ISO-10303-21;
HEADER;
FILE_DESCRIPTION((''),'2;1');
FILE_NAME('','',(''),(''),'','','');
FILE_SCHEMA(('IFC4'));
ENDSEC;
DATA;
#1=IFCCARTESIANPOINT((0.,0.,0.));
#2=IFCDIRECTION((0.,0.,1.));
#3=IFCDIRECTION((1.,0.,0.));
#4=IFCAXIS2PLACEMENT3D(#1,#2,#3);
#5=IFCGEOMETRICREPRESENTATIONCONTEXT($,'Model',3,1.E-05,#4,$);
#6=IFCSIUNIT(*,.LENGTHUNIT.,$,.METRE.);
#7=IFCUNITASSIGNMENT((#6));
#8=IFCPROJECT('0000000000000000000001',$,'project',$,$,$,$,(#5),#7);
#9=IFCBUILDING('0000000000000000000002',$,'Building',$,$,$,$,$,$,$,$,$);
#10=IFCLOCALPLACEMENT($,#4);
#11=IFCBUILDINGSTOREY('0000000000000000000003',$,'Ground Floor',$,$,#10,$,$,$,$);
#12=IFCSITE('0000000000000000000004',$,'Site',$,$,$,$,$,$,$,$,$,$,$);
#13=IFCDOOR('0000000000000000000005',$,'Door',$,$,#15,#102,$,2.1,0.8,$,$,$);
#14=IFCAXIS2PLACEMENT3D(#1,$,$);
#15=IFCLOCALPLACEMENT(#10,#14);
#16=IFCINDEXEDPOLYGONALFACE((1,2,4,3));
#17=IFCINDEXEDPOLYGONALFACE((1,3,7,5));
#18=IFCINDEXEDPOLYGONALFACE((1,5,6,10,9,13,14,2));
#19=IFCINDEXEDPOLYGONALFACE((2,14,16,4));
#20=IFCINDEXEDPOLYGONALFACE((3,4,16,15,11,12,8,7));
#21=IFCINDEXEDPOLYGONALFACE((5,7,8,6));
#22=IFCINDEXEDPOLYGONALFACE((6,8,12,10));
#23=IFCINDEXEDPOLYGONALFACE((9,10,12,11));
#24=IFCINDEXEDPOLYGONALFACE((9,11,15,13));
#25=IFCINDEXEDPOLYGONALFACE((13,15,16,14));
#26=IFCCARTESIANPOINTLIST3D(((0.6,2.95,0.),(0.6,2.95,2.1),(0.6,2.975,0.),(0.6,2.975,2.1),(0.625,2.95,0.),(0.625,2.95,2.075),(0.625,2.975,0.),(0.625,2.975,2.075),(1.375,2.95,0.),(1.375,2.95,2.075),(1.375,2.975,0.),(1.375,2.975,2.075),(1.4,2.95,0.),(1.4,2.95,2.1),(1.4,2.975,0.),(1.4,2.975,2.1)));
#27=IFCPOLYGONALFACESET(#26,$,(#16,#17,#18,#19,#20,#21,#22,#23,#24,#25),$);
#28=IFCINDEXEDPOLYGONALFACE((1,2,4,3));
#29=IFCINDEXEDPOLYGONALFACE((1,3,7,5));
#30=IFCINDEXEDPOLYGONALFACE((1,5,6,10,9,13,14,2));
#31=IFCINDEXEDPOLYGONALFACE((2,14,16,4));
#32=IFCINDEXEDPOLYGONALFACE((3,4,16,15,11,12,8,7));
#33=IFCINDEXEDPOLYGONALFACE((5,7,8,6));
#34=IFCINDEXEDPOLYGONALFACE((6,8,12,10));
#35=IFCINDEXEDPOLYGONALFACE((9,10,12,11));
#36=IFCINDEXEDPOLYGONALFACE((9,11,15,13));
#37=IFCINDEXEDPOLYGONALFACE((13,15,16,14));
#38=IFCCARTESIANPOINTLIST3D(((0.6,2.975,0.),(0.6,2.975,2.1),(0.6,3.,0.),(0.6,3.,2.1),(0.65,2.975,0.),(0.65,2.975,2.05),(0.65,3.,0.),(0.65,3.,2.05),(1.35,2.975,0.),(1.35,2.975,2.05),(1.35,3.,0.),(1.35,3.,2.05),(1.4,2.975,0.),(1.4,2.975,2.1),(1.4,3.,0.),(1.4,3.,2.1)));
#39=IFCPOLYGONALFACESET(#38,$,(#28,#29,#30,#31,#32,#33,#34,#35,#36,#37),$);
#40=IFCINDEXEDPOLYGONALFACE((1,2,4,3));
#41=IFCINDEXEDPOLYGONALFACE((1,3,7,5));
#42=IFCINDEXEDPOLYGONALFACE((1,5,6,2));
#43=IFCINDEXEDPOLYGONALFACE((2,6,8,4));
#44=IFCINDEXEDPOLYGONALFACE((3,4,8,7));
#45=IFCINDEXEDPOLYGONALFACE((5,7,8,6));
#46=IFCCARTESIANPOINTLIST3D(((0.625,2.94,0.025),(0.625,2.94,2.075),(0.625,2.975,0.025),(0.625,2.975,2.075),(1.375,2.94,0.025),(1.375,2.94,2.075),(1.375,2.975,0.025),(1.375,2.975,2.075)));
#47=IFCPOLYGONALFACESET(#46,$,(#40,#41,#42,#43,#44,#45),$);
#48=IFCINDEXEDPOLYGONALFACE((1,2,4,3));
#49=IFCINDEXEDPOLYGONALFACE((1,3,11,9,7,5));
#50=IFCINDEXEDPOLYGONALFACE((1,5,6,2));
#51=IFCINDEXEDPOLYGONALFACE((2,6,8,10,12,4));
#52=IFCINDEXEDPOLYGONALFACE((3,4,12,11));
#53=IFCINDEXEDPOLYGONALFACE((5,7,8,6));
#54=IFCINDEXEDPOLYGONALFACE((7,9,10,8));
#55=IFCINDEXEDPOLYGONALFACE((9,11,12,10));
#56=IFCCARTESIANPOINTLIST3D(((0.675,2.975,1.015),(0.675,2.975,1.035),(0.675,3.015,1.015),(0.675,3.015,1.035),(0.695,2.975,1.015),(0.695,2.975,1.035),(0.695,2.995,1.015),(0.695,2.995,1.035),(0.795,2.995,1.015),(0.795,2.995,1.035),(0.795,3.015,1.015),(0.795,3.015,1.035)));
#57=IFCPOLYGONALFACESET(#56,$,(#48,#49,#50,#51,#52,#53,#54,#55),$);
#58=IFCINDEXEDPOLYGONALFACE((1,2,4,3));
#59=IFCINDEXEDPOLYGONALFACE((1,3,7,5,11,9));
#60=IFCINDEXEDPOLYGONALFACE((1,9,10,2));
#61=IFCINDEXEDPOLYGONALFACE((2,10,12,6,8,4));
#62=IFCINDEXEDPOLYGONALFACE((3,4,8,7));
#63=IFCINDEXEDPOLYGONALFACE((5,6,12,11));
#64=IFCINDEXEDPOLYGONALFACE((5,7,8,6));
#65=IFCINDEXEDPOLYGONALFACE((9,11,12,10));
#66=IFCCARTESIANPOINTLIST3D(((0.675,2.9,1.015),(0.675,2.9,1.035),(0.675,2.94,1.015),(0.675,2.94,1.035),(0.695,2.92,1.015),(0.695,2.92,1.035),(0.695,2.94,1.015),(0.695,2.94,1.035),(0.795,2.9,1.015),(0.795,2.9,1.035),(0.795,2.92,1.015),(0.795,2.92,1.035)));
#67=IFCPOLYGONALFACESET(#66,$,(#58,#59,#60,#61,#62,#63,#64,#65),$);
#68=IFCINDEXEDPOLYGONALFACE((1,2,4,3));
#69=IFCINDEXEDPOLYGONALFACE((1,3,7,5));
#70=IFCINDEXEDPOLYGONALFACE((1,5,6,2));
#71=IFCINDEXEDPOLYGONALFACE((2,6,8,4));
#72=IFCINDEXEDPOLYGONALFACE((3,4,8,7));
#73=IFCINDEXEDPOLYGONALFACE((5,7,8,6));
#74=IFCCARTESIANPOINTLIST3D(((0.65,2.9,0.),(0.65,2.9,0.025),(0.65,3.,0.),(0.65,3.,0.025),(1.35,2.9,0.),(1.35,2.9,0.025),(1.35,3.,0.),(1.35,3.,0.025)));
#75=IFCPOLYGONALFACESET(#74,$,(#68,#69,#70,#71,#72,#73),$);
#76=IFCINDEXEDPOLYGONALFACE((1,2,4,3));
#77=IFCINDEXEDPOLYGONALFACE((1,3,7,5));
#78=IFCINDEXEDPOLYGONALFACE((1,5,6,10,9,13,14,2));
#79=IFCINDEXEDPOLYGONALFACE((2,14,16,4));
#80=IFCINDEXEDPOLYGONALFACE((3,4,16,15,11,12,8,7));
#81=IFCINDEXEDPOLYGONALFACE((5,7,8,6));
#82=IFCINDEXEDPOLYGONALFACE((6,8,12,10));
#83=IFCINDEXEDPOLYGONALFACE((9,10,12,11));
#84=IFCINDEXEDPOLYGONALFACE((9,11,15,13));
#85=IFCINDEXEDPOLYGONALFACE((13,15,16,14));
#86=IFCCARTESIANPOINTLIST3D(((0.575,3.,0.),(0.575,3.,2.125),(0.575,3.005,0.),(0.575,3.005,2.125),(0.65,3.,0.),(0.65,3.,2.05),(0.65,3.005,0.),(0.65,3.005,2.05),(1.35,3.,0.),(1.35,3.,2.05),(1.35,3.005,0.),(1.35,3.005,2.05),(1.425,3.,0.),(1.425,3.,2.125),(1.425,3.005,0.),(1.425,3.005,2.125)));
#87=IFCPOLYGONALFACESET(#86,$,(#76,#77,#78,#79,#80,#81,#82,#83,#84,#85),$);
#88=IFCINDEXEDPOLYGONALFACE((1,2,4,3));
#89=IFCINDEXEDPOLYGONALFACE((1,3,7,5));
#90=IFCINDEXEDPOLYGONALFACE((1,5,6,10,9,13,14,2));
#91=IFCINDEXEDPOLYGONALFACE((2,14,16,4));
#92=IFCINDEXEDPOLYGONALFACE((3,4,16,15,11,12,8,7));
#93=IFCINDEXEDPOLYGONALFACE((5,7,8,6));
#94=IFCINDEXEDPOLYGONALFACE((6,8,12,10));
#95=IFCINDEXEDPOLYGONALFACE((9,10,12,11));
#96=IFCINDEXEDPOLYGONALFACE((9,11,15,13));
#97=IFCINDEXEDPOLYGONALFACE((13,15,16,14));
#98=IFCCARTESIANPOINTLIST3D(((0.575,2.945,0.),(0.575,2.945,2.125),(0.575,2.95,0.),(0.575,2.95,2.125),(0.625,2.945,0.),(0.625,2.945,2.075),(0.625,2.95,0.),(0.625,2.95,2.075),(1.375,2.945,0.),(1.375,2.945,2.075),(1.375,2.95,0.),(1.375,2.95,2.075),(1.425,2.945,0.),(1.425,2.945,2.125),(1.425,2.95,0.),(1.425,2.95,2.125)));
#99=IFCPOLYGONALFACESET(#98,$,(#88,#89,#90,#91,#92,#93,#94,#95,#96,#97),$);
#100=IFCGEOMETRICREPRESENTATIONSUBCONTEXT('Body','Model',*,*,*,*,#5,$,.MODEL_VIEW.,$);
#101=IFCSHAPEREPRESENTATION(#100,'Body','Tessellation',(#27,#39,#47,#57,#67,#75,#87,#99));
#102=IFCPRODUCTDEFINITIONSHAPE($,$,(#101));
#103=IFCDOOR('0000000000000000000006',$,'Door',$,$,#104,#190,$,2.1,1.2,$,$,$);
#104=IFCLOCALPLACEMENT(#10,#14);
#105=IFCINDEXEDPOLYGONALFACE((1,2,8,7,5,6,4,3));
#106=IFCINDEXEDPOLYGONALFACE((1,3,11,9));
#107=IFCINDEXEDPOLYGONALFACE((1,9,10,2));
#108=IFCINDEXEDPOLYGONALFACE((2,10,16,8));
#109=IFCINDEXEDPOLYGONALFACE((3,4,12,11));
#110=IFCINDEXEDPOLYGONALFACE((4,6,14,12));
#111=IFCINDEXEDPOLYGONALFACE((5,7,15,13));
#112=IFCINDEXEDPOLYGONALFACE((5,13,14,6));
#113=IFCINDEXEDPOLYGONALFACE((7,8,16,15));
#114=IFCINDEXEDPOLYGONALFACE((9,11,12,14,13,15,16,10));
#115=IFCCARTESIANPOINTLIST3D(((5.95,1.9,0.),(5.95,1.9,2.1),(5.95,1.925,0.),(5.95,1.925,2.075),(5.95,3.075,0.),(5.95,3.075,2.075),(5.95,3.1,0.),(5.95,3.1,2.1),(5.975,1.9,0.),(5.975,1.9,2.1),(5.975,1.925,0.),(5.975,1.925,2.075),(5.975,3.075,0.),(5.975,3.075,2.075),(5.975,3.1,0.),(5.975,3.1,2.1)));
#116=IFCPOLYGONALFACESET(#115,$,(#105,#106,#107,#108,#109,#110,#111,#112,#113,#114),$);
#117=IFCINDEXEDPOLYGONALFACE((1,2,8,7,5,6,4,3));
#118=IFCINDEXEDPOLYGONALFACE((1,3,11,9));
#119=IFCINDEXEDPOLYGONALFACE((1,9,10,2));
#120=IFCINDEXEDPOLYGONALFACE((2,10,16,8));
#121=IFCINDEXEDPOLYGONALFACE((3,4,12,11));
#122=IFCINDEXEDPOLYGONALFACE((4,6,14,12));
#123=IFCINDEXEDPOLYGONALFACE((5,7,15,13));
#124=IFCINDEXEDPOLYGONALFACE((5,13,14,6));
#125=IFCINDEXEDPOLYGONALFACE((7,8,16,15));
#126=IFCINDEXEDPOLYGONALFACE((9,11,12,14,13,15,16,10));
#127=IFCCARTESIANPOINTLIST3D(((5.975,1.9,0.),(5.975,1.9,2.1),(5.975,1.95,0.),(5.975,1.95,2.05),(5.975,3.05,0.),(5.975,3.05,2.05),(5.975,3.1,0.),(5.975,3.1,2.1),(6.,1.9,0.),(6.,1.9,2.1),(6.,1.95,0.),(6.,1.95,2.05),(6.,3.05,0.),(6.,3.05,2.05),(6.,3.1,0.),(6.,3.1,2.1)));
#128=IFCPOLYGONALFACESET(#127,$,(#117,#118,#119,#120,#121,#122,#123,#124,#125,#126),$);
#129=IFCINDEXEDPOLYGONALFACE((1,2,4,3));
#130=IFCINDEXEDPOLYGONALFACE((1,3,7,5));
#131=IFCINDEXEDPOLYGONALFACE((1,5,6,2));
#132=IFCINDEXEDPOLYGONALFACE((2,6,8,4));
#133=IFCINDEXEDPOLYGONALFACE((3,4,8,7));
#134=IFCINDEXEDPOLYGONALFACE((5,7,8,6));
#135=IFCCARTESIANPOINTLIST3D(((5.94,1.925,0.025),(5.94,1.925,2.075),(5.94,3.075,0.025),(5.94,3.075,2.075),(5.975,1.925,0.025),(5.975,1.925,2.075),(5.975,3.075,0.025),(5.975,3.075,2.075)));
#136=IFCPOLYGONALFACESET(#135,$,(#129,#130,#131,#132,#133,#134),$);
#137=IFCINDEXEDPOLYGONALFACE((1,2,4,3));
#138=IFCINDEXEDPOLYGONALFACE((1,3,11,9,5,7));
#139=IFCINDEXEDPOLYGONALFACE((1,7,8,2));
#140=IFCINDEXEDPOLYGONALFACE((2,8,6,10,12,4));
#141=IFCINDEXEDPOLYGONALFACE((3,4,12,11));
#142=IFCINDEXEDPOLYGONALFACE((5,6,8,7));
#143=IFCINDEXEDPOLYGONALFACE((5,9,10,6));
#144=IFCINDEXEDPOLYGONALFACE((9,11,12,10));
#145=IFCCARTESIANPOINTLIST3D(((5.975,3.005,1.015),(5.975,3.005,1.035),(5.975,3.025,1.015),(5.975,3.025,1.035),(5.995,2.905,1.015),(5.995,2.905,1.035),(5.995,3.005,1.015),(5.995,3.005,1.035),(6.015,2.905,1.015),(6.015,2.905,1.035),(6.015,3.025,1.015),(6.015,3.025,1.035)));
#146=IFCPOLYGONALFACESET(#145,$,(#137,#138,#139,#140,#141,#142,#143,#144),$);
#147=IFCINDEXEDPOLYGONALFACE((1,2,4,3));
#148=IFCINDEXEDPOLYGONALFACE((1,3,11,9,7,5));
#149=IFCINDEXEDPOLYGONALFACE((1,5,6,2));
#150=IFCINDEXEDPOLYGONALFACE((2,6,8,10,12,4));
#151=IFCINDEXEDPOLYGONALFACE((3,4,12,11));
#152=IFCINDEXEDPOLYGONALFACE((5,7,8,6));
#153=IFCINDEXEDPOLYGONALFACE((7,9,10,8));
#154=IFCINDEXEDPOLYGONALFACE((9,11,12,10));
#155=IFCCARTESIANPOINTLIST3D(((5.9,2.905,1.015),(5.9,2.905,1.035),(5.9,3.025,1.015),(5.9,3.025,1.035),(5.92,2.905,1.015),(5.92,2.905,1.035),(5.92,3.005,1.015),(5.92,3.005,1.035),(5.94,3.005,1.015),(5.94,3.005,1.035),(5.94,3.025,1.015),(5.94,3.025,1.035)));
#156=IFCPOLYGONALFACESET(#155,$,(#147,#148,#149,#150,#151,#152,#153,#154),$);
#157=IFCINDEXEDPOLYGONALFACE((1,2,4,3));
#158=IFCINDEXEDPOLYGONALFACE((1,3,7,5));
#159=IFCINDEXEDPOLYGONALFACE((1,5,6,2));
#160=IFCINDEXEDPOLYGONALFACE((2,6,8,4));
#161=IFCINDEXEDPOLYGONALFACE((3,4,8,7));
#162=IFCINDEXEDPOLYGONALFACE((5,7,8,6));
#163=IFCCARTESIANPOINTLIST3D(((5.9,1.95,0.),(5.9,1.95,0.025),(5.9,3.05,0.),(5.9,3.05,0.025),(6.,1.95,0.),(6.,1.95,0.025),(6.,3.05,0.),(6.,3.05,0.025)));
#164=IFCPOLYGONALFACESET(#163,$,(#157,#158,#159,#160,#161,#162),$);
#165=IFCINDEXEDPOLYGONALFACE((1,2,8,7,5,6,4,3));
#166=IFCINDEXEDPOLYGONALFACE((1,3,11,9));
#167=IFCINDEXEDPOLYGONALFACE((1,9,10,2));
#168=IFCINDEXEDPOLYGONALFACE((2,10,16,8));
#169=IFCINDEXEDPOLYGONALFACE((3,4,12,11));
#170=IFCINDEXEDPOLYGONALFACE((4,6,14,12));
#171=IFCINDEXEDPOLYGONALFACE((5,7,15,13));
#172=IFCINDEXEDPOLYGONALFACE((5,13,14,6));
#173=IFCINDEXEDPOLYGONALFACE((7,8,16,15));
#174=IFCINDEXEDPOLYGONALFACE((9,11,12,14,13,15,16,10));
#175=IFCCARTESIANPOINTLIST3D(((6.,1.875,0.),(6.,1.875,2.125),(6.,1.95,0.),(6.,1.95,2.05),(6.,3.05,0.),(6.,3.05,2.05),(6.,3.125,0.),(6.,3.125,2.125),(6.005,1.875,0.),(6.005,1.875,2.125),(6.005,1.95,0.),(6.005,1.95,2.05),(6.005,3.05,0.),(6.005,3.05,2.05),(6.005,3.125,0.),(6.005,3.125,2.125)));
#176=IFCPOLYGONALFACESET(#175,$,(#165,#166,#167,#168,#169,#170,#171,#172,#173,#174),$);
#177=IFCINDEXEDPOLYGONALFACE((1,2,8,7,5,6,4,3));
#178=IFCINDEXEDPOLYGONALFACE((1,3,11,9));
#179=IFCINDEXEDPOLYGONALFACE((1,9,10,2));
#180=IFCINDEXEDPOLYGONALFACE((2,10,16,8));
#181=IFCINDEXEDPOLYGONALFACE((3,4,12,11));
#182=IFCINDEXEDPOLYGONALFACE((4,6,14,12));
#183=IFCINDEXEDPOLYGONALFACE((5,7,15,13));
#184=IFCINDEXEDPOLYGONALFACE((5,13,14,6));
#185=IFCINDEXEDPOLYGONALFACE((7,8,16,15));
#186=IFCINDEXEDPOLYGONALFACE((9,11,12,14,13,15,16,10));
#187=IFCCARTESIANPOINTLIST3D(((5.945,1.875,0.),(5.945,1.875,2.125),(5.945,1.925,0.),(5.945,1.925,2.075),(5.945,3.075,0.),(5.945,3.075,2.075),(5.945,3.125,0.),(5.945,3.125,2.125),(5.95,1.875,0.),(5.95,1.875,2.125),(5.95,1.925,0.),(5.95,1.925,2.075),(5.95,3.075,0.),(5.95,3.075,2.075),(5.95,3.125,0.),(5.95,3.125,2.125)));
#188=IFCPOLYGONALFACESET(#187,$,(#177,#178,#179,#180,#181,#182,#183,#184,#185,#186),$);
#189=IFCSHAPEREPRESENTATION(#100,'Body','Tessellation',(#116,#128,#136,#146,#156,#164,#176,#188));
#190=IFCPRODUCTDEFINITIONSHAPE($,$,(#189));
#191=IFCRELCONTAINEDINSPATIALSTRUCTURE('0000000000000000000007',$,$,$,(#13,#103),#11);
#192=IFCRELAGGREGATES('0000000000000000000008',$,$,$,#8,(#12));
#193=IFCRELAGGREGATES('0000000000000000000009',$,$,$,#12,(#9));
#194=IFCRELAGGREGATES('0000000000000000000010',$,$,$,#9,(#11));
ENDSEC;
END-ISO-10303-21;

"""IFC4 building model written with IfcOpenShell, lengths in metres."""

from ifc_helpers import new_model, si_unit, frame, origin_with_axes, place, context, subcontext, project, spatial, line, indexed_curve, outline, extrude, element, save


model = new_model("IFC4")

# Units and contexts
model_context = context("Model", 3, precision=1e-05, world=origin_with_axes())
body_context = subcontext(model_context, "Body", "Model", "MODEL_VIEW")
ifc_project = project(units=[si_unit("LENGTHUNIT", "METRE")], contexts=[model_context])

# Site, building, storey
site = spatial("IfcSite", under=ifc_project, Name="Site")
building = spatial("IfcBuilding", under=site, Name="Building")
storey_placement = place(None, origin_with_axes())
storey = spatial("IfcBuildingStorey", under=building, at=storey_placement, Name="Ground Floor")

# Doors
door_1_placement = place(storey_placement, frame((1.4, 3.0, 0.0), z_axis=(0.0, 0.0, 1.0), x_axis=(-1.0, 0.0, 0.0)))
element("IfcDoor", 1, at=door_1_placement, inside=storey, Name="Door", OverallHeight=2.1, OverallWidth=0.8, context=body_context, shape_type="SweptSolid", body=[
    extrude(outline(indexed_curve([(0.0, 0.0), (0.0, 2.1), (0.8, 2.1), (0.8, 0.0), (0.775, 0.0), (0.775, 2.075), (0.025, 2.075), (0.025, 0.0)], segments=[line(1, 2, 3, 4, 5, 6, 7, 8, 1)])), frame((0.0, 0.025, 0.0), z_axis=(0.0, -1.0, 0.0), x_axis=(1.0, 0.0, 0.0)), (0.0, 0.0, -1.0), 0.025),
    extrude(outline(indexed_curve([(0.0, 0.0), (0.0, 2.1), (0.8, 2.1), (0.8, 0.0), (0.75, 0.0), (0.75, 2.05), (0.05, 2.05), (0.05, 0.0)], segments=[line(1, 2, 3, 4, 5, 6, 7, 8, 1)])), frame((0.0, 0.0, 0.0), z_axis=(0.0, -1.0, 0.0), x_axis=(1.0, 0.0, 0.0)), (0.0, 0.0, -1.0), 0.025),
    extrude(outline(indexed_curve([(0.0, 0.0), (0.75, 0.0), (0.75, 0.035), (0.0, 0.035)], segments=[line(1, 2, 3, 4, 1)])), frame((0.025, 0.025, 0.025), z_axis=(0.0, 0.0, 1.0), x_axis=(1.0, 0.0, 0.0)), (0.0, 0.0, 1.0), 2.05),
    extrude(outline(indexed_curve([(0.0, 0.0), (0.0, -0.04), (-0.12, -0.04), (-0.12, -0.02), (-0.02, -0.02), (-0.02, 0.0)], segments=[line(1, 2, 3, 4, 5, 6, 1)])), frame((0.725, 0.025, 1.015), z_axis=(0.0, 0.0, 1.0), x_axis=(1.0, 0.0, 0.0)), (0.0, 0.0, 1.0), 0.02),
    extrude(outline(indexed_curve([(0.0, 0.0), (0.0, 0.04), (-0.12, 0.04), (-0.12, 0.02), (-0.02, 0.02), (-0.02, 0.0)], segments=[line(1, 2, 3, 4, 5, 6, 1)])), frame((0.725, 0.06, 1.015), z_axis=(0.0, 0.0, 1.0), x_axis=(1.0, 0.0, 0.0)), (0.0, 0.0, 1.0), 0.02),
    extrude(outline(indexed_curve([(0.0, 0.0), (0.7, 0.0), (0.7, 0.1), (0.0, 0.1)], segments=[line(1, 2, 3, 4, 1)])), frame((0.05, 0.0, 0.0), z_axis=(0.0, 0.0, 1.0), x_axis=(1.0, 0.0, 0.0)), (0.0, 0.0, 1.0), 0.025),
    extrude(outline(indexed_curve([(0.0, 0.0), (0.0, 2.125), (0.85, 2.125), (0.85, 0.0), (0.775, 0.0), (0.775, 2.05), (0.075, 2.05), (0.075, 0.0)], segments=[line(1, 2, 3, 4, 5, 6, 7, 8, 1)])), frame((-0.025, -0.005, 0.0), z_axis=(0.0, -1.0, 0.0), x_axis=(1.0, 0.0, 0.0)), (0.0, 0.0, -1.0), 0.005),
    extrude(outline(indexed_curve([(0.0, 0.0), (0.0, 2.125), (0.85, 2.125), (0.85, 0.0), (0.8, 0.0), (0.8, 2.075), (0.05, 2.075), (0.05, 0.0)], segments=[line(1, 2, 3, 4, 5, 6, 7, 8, 1)])), frame((-0.025, 0.05, 0.0), z_axis=(0.0, -1.0, 0.0), x_axis=(1.0, 0.0, 0.0)), (0.0, 0.0, -1.0), 0.005),
])
door_2_placement = place(storey_placement, frame((6.0, 1.9, 0.0), z_axis=(0.0, 0.0, 1.0), x_axis=(0.0, 1.0, 0.0)))
element("IfcDoor", 2, at=door_2_placement, inside=storey, Name="Door", OverallHeight=2.1, OverallWidth=1.2, context=body_context, shape_type="SweptSolid", body=[
    extrude(outline(indexed_curve([(0.0, 0.0), (0.0, 2.1), (1.2, 2.1), (1.2, 0.0), (1.175, 0.0), (1.175, 2.075), (0.025, 2.075), (0.025, 0.0)], segments=[line(1, 2, 3, 4, 5, 6, 7, 8, 1)])), frame((0.0, 0.025, 0.0), z_axis=(0.0, -1.0, 0.0), x_axis=(1.0, 0.0, 0.0)), (0.0, 0.0, -1.0), 0.025),
    extrude(outline(indexed_curve([(0.0, 0.0), (0.0, 2.1), (1.2, 2.1), (1.2, 0.0), (1.15, 0.0), (1.15, 2.05), (0.05, 2.05), (0.05, 0.0)], segments=[line(1, 2, 3, 4, 5, 6, 7, 8, 1)])), frame((0.0, 0.0, 0.0), z_axis=(0.0, -1.0, 0.0), x_axis=(1.0, 0.0, 0.0)), (0.0, 0.0, -1.0), 0.025),
    extrude(outline(indexed_curve([(0.0, 0.0), (1.15, 0.0), (1.15, 0.035), (0.0, 0.035)], segments=[line(1, 2, 3, 4, 1)])), frame((0.025, 0.025, 0.025), z_axis=(0.0, 0.0, 1.0), x_axis=(1.0, 0.0, 0.0)), (0.0, 0.0, 1.0), 2.05),
    extrude(outline(indexed_curve([(0.0, 0.0), (0.0, -0.04), (-0.12, -0.04), (-0.12, -0.02), (-0.02, -0.02), (-0.02, 0.0)], segments=[line(1, 2, 3, 4, 5, 6, 1)])), frame((1.125, 0.025, 1.015), z_axis=(0.0, 0.0, 1.0), x_axis=(1.0, 0.0, 0.0)), (0.0, 0.0, 1.0), 0.02),
    extrude(outline(indexed_curve([(0.0, 0.0), (0.0, 0.04), (-0.12, 0.04), (-0.12, 0.02), (-0.02, 0.02), (-0.02, 0.0)], segments=[line(1, 2, 3, 4, 5, 6, 1)])), frame((1.125, 0.06, 1.015), z_axis=(0.0, 0.0, 1.0), x_axis=(1.0, 0.0, 0.0)), (0.0, 0.0, 1.0), 0.02),
    extrude(outline(indexed_curve([(0.0, 0.0), (1.1, 0.0), (1.1, 0.1), (0.0, 0.1)], segments=[line(1, 2, 3, 4, 1)])), frame((0.05, 0.0, 0.0), z_axis=(0.0, 0.0, 1.0), x_axis=(1.0, 0.0, 0.0)), (0.0, 0.0, 1.0), 0.025),
    extrude(outline(indexed_curve([(0.0, 0.0), (0.0, 2.125), (1.25, 2.125), (1.25, 0.0), (1.175, 0.0), (1.175, 2.05), (0.075, 2.05), (0.075, 0.0)], segments=[line(1, 2, 3, 4, 5, 6, 7, 8, 1)])), frame((-0.025, -0.005, 0.0), z_axis=(0.0, -1.0, 0.0), x_axis=(1.0, 0.0, 0.0)), (0.0, 0.0, -1.0), 0.005),
    extrude(outline(indexed_curve([(0.0, 0.0), (0.0, 2.125), (1.25, 2.125), (1.25, 0.0), (1.2, 0.0), (1.2, 2.075), (0.05, 2.075), (0.05, 0.0)], segments=[line(1, 2, 3, 4, 5, 6, 7, 8, 1)])), frame((-0.025, 0.05, 0.0), z_axis=(0.0, -1.0, 0.0), x_axis=(1.0, 0.0, 0.0)), (0.0, 0.0, -1.0), 0.005),
])

save(model, "model.ifc")
